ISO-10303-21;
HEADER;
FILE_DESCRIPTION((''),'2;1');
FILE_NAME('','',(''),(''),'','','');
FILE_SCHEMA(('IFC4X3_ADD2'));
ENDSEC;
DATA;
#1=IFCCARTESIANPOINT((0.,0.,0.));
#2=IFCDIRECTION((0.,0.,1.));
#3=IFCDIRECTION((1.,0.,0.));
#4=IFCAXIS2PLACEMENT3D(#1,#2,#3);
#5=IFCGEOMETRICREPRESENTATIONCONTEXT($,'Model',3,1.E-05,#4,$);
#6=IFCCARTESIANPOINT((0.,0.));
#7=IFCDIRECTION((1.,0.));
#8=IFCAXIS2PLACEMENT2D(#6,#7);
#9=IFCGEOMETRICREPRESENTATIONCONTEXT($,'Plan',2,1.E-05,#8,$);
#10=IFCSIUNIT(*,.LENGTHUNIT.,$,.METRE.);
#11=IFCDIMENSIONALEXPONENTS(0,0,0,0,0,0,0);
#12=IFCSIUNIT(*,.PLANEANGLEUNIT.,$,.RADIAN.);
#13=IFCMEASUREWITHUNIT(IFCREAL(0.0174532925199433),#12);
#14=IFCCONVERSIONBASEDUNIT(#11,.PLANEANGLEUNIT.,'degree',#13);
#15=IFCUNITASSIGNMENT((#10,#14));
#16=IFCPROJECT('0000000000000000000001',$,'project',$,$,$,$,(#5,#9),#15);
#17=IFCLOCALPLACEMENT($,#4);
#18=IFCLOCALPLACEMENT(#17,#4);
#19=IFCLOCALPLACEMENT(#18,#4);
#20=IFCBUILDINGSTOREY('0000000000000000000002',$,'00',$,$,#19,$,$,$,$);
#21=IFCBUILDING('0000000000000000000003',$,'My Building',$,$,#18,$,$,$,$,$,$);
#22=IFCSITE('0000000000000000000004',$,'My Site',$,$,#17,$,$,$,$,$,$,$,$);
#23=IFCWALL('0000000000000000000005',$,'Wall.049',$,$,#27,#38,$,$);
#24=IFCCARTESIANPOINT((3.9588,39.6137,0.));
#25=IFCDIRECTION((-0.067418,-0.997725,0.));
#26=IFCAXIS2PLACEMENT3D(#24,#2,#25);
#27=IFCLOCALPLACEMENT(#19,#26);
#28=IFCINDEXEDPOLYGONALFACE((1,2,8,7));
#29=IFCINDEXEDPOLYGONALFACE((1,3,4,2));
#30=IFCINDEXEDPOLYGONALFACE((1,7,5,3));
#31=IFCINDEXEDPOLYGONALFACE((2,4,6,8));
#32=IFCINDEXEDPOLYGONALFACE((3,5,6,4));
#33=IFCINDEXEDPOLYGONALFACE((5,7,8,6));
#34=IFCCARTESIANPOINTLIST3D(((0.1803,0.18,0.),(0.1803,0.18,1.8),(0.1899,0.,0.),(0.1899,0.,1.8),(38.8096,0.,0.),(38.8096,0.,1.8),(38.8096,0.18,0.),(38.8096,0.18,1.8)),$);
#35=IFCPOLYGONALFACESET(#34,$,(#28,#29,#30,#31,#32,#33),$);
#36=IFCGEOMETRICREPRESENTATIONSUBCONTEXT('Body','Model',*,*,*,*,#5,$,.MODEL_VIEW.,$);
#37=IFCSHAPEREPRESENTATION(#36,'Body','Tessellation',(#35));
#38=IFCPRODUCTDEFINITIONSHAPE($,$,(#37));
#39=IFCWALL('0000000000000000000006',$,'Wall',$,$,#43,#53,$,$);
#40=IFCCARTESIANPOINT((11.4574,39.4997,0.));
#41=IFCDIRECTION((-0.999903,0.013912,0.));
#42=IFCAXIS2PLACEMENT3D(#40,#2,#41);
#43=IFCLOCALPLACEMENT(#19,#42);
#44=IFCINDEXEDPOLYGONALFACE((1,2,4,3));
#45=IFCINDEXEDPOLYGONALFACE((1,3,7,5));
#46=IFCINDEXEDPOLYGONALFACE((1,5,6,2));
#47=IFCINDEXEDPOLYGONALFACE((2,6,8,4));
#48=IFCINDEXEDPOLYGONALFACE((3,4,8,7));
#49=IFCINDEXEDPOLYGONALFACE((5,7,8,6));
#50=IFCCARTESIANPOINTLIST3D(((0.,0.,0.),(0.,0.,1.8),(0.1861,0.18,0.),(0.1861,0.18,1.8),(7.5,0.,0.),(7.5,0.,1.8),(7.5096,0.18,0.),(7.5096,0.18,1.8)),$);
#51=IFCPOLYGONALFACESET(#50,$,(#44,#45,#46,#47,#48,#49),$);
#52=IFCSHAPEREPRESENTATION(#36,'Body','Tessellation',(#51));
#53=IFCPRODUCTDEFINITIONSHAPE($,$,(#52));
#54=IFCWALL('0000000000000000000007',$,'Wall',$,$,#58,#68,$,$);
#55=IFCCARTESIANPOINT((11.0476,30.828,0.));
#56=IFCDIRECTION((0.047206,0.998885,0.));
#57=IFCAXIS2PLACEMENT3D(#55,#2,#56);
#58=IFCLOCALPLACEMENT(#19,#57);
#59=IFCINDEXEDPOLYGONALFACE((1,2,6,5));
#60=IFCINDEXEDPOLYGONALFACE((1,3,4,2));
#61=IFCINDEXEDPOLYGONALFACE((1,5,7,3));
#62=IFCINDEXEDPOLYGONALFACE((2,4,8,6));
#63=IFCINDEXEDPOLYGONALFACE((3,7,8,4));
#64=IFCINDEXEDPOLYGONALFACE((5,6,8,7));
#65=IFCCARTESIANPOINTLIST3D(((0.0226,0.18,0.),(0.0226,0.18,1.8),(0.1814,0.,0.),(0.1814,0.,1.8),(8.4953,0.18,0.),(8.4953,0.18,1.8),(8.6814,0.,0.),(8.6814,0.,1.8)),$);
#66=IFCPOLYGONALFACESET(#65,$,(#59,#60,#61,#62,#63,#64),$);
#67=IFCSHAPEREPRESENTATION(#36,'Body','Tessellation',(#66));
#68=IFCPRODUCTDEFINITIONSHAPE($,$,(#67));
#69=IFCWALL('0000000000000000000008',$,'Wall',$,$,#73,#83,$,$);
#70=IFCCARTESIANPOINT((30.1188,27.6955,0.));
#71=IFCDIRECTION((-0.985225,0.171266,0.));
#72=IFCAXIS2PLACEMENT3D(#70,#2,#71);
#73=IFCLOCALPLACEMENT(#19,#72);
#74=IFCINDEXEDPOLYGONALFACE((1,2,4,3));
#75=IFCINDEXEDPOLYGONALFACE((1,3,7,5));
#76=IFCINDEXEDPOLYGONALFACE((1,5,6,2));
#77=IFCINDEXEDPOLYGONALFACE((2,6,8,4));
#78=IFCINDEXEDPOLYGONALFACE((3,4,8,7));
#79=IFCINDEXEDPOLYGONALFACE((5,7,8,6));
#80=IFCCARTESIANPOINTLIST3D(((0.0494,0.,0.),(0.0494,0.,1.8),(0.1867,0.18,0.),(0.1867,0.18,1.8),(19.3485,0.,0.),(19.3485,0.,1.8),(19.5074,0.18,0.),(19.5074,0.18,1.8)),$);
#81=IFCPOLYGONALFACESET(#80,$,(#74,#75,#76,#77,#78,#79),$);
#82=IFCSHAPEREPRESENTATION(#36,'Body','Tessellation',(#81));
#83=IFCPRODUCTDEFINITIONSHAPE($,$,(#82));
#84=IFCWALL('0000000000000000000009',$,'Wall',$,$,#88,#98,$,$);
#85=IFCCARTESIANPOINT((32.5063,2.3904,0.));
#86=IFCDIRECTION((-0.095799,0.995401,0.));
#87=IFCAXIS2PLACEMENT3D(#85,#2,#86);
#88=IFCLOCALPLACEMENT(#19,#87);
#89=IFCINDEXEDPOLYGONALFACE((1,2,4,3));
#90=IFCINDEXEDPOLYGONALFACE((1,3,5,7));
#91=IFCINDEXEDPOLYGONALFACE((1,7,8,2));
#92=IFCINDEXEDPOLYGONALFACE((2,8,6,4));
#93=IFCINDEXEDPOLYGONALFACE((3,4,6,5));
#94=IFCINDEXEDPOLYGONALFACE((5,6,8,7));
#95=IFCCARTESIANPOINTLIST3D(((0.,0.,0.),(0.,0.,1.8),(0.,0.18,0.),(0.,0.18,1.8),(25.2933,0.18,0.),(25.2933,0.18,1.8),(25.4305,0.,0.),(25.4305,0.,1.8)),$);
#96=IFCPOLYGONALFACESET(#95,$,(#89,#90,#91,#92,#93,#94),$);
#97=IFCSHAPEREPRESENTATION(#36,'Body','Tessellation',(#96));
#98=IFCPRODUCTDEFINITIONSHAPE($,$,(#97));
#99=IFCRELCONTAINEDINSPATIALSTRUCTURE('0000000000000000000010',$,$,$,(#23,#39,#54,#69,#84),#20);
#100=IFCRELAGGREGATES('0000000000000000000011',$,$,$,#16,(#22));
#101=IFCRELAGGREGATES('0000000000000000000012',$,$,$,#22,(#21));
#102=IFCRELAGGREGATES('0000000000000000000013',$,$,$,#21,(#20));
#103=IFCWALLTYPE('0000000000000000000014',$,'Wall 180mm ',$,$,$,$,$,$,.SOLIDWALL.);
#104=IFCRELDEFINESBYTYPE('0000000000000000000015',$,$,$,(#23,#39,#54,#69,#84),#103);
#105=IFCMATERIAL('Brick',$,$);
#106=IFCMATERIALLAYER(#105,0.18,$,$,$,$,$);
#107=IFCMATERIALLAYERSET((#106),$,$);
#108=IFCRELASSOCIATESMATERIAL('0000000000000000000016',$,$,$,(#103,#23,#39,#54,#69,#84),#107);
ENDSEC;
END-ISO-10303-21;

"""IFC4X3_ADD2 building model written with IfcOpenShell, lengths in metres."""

from ifc_helpers import new_model, entity, si_unit, converted_unit, frame, origin_with_axes, origin_2d_with_axis, place, context, subcontext, project, spatial, indexed_curve, outline, extrude, clip, halfspace, material, layer, layer_set, layer_usage, type_object, element, save


model = new_model("IFC4X3_ADD2")

# Units and contexts
model_context = context("Model", 3, precision=1e-05, world=origin_with_axes())
plan_context = context("Plan", 2, precision=1e-05, world=origin_2d_with_axis())
body_context = subcontext(model_context, "Body", "Model", "MODEL_VIEW")
ifc_project = project(units=[si_unit("LENGTHUNIT", "METRE"), converted_unit("PLANEANGLEUNIT", "degree", entity("IfcReal", 0.0174532925199433), si_unit("PLANEANGLEUNIT", "RADIAN"), dimensions=[0, 0, 0, 0, 0, 0, 0])], contexts=[model_context, plan_context])

# Site, building, storey
site_placement = place(None, origin_with_axes())
site = spatial("IfcSite", under=ifc_project, at=site_placement, Name="My Site")
building_placement = place(site_placement, origin_with_axes())
building = spatial("IfcBuilding", under=site, at=building_placement, Name="My Building")
storey_placement = place(building_placement, origin_with_axes())
storey = spatial("IfcBuildingStorey", under=building, at=storey_placement, Name="00")

# Walls
ifc_material_1 = material(Name="Brick")
ifc_layer_1 = layer(ifc_material_1, 0.18)
ifc_layer_set_1 = layer_set([ifc_layer_1])
ifc_layer_usage_1 = layer_usage(ifc_layer_set_1, "AXIS2", "POSITIVE", 0.0)
wall_type_1 = type_object("IfcWallType", Name="Wall 180mm ", PredefinedType="SOLIDWALL", material=ifc_layer_set_1)
wall_1_placement = place(storey_placement, frame((3.9588, 39.6137, 0.0), z_axis=(0.0, 0.0, 1.0), x_axis=(-0.067418, -0.997725, 0.0)))
element("IfcWall", 1, at=wall_1_placement, inside=storey, type_object=wall_type_1, material=ifc_layer_usage_1, Name="Wall.049", context=body_context, shape_type="Clipping", body=[
    clip(extrude(outline(indexed_curve([(0.0, 0.0), (0.0, 0.18), (38.8096, 0.18), (38.8096, 0.0), (0.0, 0.0)], self_intersect=False)), origin_with_axes(), (0.0, 0.0, 1.0), 1.8), halfspace(frame((0.1899, 0.0, 0.0), z_axis=(-0.18, -0.009647, 0.0), x_axis=(-0.053519, 0.998567, 0.0)), False)),
])
ifc_layer_usage_2 = layer_usage(ifc_layer_set_1, "AXIS2", "POSITIVE", 0.0)
wall_2_placement = place(storey_placement, frame((11.4574, 39.4997, 0.0), z_axis=(0.0, 0.0, 1.0), x_axis=(-0.999903, 0.013912, 0.0)))
element("IfcWall", 2, at=wall_2_placement, inside=storey, type_object=wall_type_1, material=ifc_layer_usage_2, Name="Wall", context=body_context, shape_type="Clipping", body=[
    clip(clip(extrude(outline(indexed_curve([(0.0, 0.0), (0.0, 0.18), (7.5096, 0.18), (7.5096, 0.0), (0.0, 0.0)], self_intersect=False)), origin_with_axes(), (0.0, 0.0, 1.0), 1.8), halfspace(frame((0.0, 0.0, 0.0), z_axis=(-0.695227, 0.718791, 0.0), x_axis=(0.71879, 0.695227, 0.0)), False)), halfspace(frame((7.5, 0.0, 0.0), z_axis=(0.18, -0.009649, 0.0), x_axis=(-0.053531, -0.998566, 0.0)), False)),
])
ifc_layer_usage_3 = layer_usage(ifc_layer_set_1, "AXIS2", "POSITIVE", 0.0)
wall_3_placement = place(storey_placement, frame((11.0476, 30.828, 0.0), z_axis=(0.0, 0.0, 1.0), x_axis=(0.047206, 0.998885, 0.0)))
element("IfcWall", 3, at=wall_3_placement, inside=storey, type_object=wall_type_1, material=ifc_layer_usage_3, Name="Wall", context=body_context, shape_type="Clipping", body=[
    clip(clip(extrude(outline(indexed_curve([(0.0, 0.0), (0.0, 0.18), (8.6814, 0.18), (8.6814, 0.0), (0.0, 0.0)], self_intersect=False)), origin_with_axes(), (0.0, 0.0, 1.0), 1.8), halfspace(frame((0.1814, 0.0, 0.0), z_axis=(-0.749849, -0.66161, 0.0), x_axis=(-0.66161, 0.749848, 0.0)), False)), halfspace(frame((8.6814, 0.0, 0.0), z_axis=(0.695237, 0.718781, 0.0), x_axis=(0.71878, -0.695237, 0.0)), False)),
])
ifc_layer_usage_4 = layer_usage(ifc_layer_set_1, "AXIS2", "POSITIVE", 0.0)
wall_4_placement = place(storey_placement, frame((30.1188, 27.6955, 0.0), z_axis=(0.0, 0.0, 1.0), x_axis=(-0.985225, 0.171266, 0.0)))
element("IfcWall", 4, at=wall_4_placement, inside=storey, type_object=wall_type_1, material=ifc_layer_usage_4, Name="Wall", context=body_context, shape_type="Clipping", body=[
    clip(clip(extrude(outline(indexed_curve([(0.0, 0.0), (0.0, 0.18), (19.5299, 0.18), (19.5299, 0.0), (0.0, 0.0)], self_intersect=False)), origin_with_axes(), (0.0, 0.0, 1.0), 1.8), halfspace(frame((0.0494, 0.0, 0.0), z_axis=(-0.795258, 0.606271, 0.0), x_axis=(0.606271, 0.795258, 0.0)), False)), halfspace(frame((19.3485, 0.0, 0.0), z_axis=(0.749857, -0.6616, 0.0), x_axis=(-0.6616, -0.749857, 0.0)), False)),
])
ifc_layer_usage_5 = layer_usage(ifc_layer_set_1, "AXIS2", "POSITIVE", 0.0)
wall_5_placement = place(storey_placement, frame((32.5063, 2.3904, 0.0), z_axis=(0.0, 0.0, 1.0), x_axis=(-0.095799, 0.995401, 0.0)))
element("IfcWall", 5, at=wall_5_placement, inside=storey, type_object=wall_type_1, material=ifc_layer_usage_5, Name="Wall", context=body_context, shape_type="Clipping", body=[
    clip(extrude(outline(indexed_curve([(0.0, 0.0), (0.0, 0.18), (25.48, 0.18), (25.48, 0.0), (0.0, 0.0)], self_intersect=False)), origin_with_axes(), (0.0, 0.0, 1.0), 1.8), halfspace(frame((25.4305, 0.0, 0.0), z_axis=(0.795259, 0.606269, 0.0), x_axis=(0.606269, -0.795259, 0.0)), False)),
])

save(model, "model.ifc")
